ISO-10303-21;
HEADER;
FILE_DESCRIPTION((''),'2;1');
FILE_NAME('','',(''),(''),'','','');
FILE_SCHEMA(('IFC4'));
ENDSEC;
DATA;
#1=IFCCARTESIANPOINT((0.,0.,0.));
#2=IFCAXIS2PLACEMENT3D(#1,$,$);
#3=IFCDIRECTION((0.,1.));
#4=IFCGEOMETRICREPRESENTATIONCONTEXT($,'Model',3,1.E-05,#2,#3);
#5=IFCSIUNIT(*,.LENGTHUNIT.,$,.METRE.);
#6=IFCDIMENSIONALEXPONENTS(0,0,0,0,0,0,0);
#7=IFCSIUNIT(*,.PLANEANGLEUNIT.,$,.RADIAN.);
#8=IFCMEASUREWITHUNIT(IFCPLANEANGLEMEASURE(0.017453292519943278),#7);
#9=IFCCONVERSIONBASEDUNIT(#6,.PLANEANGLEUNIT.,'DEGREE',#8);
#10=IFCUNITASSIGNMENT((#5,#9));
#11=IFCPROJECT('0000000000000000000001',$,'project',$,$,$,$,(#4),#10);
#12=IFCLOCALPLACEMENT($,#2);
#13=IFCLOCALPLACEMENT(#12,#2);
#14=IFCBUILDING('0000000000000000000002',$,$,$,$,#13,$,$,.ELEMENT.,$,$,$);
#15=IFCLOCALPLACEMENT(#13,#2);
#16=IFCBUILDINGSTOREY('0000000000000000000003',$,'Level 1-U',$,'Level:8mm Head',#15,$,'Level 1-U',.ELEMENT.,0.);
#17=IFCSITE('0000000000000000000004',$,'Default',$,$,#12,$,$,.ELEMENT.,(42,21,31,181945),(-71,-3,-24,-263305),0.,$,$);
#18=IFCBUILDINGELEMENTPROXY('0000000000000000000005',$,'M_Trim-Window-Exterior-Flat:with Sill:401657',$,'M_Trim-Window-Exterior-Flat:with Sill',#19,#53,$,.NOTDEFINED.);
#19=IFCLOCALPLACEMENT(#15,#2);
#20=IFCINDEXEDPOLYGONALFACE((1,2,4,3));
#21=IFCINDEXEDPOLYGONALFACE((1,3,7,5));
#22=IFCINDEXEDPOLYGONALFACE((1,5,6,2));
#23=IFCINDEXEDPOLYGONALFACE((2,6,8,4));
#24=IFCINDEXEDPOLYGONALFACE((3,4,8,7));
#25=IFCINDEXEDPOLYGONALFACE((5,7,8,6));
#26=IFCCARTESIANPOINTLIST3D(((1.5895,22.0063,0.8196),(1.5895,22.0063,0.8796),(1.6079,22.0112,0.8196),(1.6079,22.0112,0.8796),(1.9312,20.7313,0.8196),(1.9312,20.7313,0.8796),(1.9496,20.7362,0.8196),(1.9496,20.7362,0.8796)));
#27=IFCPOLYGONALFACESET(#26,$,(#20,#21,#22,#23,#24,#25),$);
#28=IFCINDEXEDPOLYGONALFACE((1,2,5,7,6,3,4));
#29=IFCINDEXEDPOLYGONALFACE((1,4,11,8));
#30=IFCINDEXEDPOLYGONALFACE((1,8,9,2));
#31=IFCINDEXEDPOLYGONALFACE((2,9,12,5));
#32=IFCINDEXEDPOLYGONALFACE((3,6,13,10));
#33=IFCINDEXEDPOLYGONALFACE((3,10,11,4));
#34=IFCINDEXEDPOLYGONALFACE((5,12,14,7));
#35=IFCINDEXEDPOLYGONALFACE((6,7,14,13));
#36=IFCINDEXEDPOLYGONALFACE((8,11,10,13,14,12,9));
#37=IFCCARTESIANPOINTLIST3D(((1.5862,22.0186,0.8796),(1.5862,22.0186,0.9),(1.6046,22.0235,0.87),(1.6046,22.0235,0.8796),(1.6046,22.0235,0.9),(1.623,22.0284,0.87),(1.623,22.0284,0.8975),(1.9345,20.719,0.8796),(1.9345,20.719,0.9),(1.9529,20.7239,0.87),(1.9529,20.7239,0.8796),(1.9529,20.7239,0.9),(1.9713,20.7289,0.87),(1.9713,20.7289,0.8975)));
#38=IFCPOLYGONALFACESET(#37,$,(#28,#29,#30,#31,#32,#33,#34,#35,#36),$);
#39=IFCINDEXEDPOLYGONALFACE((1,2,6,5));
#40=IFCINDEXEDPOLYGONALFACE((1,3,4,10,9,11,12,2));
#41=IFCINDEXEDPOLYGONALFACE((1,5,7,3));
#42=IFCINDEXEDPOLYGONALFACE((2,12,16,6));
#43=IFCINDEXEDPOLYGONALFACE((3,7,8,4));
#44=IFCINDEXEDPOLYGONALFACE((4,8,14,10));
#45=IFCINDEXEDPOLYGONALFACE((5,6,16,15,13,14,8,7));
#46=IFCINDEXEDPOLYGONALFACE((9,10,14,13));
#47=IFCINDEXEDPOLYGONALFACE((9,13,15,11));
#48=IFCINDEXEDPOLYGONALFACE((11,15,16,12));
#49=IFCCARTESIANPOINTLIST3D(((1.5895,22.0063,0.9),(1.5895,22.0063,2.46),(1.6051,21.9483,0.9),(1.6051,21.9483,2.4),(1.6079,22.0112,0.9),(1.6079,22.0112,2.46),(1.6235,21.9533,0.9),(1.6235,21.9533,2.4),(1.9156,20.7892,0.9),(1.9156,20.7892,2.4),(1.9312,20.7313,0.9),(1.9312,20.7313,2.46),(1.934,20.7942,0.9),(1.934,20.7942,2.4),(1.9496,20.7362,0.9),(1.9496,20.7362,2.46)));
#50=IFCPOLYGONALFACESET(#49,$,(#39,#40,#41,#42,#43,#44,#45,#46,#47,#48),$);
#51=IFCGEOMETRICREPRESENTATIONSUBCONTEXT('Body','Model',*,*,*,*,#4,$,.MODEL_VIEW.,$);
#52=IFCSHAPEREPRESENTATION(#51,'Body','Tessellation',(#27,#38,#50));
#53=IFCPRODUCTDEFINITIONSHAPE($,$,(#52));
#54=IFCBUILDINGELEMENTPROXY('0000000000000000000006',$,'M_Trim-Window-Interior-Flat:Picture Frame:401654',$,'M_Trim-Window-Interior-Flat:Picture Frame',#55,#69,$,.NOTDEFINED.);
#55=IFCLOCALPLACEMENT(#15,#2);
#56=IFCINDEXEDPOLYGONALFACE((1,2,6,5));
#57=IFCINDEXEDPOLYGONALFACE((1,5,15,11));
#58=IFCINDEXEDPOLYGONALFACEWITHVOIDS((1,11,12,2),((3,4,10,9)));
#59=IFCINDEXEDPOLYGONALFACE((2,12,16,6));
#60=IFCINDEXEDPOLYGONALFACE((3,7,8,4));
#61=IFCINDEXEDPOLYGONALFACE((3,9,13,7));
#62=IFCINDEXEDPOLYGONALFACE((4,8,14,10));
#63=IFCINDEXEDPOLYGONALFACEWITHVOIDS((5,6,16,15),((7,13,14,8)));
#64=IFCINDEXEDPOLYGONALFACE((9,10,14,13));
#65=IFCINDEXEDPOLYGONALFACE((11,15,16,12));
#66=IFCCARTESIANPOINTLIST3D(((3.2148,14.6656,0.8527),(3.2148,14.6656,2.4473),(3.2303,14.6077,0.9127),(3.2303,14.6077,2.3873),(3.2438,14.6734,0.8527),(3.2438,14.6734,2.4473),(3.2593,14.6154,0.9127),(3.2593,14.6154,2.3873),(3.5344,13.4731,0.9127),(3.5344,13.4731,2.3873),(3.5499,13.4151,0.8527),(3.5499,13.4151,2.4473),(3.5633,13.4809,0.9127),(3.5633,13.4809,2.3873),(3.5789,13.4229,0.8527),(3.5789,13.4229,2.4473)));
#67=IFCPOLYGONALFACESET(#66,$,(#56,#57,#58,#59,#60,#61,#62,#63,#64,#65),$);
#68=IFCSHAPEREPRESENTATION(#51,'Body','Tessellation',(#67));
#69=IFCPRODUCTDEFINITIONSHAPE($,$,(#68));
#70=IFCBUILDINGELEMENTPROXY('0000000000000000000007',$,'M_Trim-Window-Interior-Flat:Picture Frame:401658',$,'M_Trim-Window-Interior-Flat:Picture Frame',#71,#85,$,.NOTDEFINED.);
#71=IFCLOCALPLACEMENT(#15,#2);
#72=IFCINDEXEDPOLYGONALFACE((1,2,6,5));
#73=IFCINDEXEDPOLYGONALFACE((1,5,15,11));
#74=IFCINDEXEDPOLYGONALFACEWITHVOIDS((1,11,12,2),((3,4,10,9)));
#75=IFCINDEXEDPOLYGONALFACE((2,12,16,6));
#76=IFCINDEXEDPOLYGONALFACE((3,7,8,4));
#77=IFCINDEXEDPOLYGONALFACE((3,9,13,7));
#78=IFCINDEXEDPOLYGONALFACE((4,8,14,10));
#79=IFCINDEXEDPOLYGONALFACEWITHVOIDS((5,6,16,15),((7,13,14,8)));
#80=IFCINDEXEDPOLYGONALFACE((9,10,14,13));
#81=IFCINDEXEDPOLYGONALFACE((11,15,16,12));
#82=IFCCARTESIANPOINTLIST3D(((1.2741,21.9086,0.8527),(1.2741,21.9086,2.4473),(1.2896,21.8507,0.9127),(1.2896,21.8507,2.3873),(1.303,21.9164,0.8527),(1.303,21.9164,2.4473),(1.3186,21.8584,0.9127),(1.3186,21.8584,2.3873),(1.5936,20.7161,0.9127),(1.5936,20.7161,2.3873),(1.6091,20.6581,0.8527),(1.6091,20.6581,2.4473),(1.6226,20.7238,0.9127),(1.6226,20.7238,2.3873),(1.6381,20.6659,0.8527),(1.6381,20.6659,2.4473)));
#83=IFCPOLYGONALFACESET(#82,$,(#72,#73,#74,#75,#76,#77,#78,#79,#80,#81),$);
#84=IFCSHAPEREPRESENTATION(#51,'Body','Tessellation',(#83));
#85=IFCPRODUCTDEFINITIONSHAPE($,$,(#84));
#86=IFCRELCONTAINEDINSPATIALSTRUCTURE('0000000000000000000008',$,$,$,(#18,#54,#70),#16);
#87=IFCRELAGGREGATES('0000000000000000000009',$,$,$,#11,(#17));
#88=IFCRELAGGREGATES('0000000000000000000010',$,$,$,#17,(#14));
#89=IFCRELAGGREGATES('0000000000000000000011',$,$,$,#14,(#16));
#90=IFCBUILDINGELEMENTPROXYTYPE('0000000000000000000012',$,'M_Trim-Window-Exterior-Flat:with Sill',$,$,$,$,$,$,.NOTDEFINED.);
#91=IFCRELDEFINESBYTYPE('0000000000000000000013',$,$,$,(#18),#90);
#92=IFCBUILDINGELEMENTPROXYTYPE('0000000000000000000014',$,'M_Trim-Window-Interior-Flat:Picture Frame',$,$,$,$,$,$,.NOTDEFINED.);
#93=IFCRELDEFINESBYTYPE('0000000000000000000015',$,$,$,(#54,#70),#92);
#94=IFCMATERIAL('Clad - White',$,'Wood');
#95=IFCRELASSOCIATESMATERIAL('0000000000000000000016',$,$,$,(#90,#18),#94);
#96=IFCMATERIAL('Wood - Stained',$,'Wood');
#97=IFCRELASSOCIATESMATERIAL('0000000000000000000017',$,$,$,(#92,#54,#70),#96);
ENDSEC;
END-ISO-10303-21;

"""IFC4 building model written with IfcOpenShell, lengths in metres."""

from ifc_helpers import new_model, entity, si_unit, converted_unit, direction, frame, origin, place, context, subcontext, project, spatial, indexed_curve, outline, extrude, source, transform, mapped, material, type_object, type_shapes, element, save


model = new_model("IFC4")

# Units and contexts
model_context = context("Model", 3, precision=1e-05, world=origin(), true_north=direction((0.0, 1.0)))
body_context = subcontext(model_context, "Body", "Model", "MODEL_VIEW")
ifc_project = project(units=[si_unit("LENGTHUNIT", "METRE"), converted_unit("PLANEANGLEUNIT", "DEGREE", entity("IfcPlaneAngleMeasure", 0.017453292519943278), si_unit("PLANEANGLEUNIT", "RADIAN"), dimensions=[0, 0, 0, 0, 0, 0, 0])], contexts=[model_context])

# Site, building, storey
site_placement = place(None, origin())
site = spatial("IfcSite", under=ifc_project, at=site_placement, Name="Default", CompositionType="ELEMENT", RefLatitude=(42, 21, 31, 181945), RefLongitude=(-71, -3, -24, -263305), RefElevation=0.0)
building_placement = place(site_placement, origin())
building = spatial("IfcBuilding", under=site, at=building_placement, CompositionType="ELEMENT")
storey_placement = place(building_placement, origin())
storey = spatial("IfcBuildingStorey", under=building, at=storey_placement, Name="Level 1-U", ObjectType="Level:8mm Head", LongName="Level 1-U", CompositionType="ELEMENT", Elevation=0.0)

# Building element proxies
ifc_material_1 = material(Name="Clad - White", Category="Wood")
ifc_material_2 = material(Name="Wood - Stained", Category="Wood")
building_element_proxy_type_1 = type_object("IfcBuildingElementProxyType", Name="M_Trim-Window-Exterior-Flat:with Sill", PredefinedType="NOTDEFINED", material=ifc_material_1)
shared_shape_1 = source(origin(), body_context, "Body", "SweptSolid", [
    extrude(outline(indexed_curve([(-0.66, -0.03), (0.66, -0.03), (0.66, 0.03), (-0.66, 0.03), (-0.66, -0.03)], self_intersect=False)), frame((0.0, -1.5504, 0.0), z_axis=(0.0, 0.0, 1.0), x_axis=(-1.0, 0.0, 0.0)), (0.0, 0.0, 1.0), 0.019),
    extrude(outline(indexed_curve([(-0.019, -0.0152), (0.0, -0.0152), (0.0, -0.0057), (0.019, -0.0057), (0.019, 0.0148), (0.0, 0.0148), (-0.019, 0.0123), (-0.019, -0.0152)], self_intersect=False)), frame((-0.6727, -1.5148, 0.019), z_axis=(1.0, 0.0, 0.0), x_axis=(0.0, 0.0, -1.0)), (0.0, 0.0, 1.0), 1.3454),
    extrude(outline(indexed_curve([(-0.795, -0.66), (0.765, -0.66), (0.765, -0.6), (-0.735, -0.6), (-0.735, 0.6), (0.765, 0.6), (0.765, 0.66), (-0.795, 0.66), (-0.795, -0.66)], self_intersect=False)), frame((0.0, -0.735, 0.0), z_axis=(0.0, 0.0, 1.0), x_axis=(0.0, -1.0, 0.0)), (0.0, 0.0, 1.0), 0.019),
])
type_shapes(building_element_proxy_type_1, [shared_shape_1])
for number, where, z_axis, x_axis, name in (
    (1, (1.7603, 21.3688, 2.4), (0.965926, 0.258819, 0.0), (-0.258819, 0.965926, 0.0), "M_Trim-Window-Exterior-Flat:with Sill:401657"),
):
    element("IfcBuildingElementProxy", number, at=place(storey_placement, frame(where, z_axis=z_axis, x_axis=x_axis)), inside=storey, type_object=building_element_proxy_type_1, material=ifc_material_1, Name=name, ObjectType="M_Trim-Window-Exterior-Flat:with Sill", PredefinedType="NOTDEFINED", context=body_context, shape_type="MappedRepresentation", body=[
        mapped(shared_shape_1, transform((0.0, 0.0, 0.0), scale=1.0)),
    ])
building_element_proxy_type_2 = type_object("IfcBuildingElementProxyType", Name="M_Trim-Window-Interior-Flat:Picture Frame", PredefinedType="NOTDEFINED", material=ifc_material_2)
shared_shape_2 = source(origin(), body_context, "Body", "SweptSolid", [
    extrude(outline(indexed_curve([(-0.6473, -0.7973), (0.6473, -0.7973), (0.6473, 0.7973), (-0.6473, 0.7973), (-0.6473, -0.7973)], self_intersect=False), holes=[indexed_curve([(-0.5873, -0.7373), (-0.5873, 0.7373), (0.5873, 0.7373), (0.5873, -0.7373), (-0.5873, -0.7373)], self_intersect=False)]), frame((0.0, -0.75, 0.0), z_axis=(0.0, 0.0, 1.0), x_axis=(-1.0, 0.0, 0.0)), (0.0, 0.0, 1.0), 0.03),
])
type_shapes(building_element_proxy_type_2, [shared_shape_2])
for number, where, z_axis, x_axis, name in (
    (2, (3.4113, 14.0481, 2.4), (-0.965926, -0.258819, 0.0), (0.258819, -0.965926, 0.0), "M_Trim-Window-Interior-Flat:Picture Frame:401654"),
    (3, (1.4706, 21.2911, 2.4), (-0.965926, -0.258819, 0.0), (0.258819, -0.965926, 0.0), "M_Trim-Window-Interior-Flat:Picture Frame:401658"),
):
    element("IfcBuildingElementProxy", number, at=place(storey_placement, frame(where, z_axis=z_axis, x_axis=x_axis)), inside=storey, type_object=building_element_proxy_type_2, material=ifc_material_2, Name=name, ObjectType="M_Trim-Window-Interior-Flat:Picture Frame", PredefinedType="NOTDEFINED", context=body_context, shape_type="MappedRepresentation", body=[
        mapped(shared_shape_2, transform((0.0, 0.0, 0.0), scale=1.0)),
    ])

save(model, "model.ifc")
